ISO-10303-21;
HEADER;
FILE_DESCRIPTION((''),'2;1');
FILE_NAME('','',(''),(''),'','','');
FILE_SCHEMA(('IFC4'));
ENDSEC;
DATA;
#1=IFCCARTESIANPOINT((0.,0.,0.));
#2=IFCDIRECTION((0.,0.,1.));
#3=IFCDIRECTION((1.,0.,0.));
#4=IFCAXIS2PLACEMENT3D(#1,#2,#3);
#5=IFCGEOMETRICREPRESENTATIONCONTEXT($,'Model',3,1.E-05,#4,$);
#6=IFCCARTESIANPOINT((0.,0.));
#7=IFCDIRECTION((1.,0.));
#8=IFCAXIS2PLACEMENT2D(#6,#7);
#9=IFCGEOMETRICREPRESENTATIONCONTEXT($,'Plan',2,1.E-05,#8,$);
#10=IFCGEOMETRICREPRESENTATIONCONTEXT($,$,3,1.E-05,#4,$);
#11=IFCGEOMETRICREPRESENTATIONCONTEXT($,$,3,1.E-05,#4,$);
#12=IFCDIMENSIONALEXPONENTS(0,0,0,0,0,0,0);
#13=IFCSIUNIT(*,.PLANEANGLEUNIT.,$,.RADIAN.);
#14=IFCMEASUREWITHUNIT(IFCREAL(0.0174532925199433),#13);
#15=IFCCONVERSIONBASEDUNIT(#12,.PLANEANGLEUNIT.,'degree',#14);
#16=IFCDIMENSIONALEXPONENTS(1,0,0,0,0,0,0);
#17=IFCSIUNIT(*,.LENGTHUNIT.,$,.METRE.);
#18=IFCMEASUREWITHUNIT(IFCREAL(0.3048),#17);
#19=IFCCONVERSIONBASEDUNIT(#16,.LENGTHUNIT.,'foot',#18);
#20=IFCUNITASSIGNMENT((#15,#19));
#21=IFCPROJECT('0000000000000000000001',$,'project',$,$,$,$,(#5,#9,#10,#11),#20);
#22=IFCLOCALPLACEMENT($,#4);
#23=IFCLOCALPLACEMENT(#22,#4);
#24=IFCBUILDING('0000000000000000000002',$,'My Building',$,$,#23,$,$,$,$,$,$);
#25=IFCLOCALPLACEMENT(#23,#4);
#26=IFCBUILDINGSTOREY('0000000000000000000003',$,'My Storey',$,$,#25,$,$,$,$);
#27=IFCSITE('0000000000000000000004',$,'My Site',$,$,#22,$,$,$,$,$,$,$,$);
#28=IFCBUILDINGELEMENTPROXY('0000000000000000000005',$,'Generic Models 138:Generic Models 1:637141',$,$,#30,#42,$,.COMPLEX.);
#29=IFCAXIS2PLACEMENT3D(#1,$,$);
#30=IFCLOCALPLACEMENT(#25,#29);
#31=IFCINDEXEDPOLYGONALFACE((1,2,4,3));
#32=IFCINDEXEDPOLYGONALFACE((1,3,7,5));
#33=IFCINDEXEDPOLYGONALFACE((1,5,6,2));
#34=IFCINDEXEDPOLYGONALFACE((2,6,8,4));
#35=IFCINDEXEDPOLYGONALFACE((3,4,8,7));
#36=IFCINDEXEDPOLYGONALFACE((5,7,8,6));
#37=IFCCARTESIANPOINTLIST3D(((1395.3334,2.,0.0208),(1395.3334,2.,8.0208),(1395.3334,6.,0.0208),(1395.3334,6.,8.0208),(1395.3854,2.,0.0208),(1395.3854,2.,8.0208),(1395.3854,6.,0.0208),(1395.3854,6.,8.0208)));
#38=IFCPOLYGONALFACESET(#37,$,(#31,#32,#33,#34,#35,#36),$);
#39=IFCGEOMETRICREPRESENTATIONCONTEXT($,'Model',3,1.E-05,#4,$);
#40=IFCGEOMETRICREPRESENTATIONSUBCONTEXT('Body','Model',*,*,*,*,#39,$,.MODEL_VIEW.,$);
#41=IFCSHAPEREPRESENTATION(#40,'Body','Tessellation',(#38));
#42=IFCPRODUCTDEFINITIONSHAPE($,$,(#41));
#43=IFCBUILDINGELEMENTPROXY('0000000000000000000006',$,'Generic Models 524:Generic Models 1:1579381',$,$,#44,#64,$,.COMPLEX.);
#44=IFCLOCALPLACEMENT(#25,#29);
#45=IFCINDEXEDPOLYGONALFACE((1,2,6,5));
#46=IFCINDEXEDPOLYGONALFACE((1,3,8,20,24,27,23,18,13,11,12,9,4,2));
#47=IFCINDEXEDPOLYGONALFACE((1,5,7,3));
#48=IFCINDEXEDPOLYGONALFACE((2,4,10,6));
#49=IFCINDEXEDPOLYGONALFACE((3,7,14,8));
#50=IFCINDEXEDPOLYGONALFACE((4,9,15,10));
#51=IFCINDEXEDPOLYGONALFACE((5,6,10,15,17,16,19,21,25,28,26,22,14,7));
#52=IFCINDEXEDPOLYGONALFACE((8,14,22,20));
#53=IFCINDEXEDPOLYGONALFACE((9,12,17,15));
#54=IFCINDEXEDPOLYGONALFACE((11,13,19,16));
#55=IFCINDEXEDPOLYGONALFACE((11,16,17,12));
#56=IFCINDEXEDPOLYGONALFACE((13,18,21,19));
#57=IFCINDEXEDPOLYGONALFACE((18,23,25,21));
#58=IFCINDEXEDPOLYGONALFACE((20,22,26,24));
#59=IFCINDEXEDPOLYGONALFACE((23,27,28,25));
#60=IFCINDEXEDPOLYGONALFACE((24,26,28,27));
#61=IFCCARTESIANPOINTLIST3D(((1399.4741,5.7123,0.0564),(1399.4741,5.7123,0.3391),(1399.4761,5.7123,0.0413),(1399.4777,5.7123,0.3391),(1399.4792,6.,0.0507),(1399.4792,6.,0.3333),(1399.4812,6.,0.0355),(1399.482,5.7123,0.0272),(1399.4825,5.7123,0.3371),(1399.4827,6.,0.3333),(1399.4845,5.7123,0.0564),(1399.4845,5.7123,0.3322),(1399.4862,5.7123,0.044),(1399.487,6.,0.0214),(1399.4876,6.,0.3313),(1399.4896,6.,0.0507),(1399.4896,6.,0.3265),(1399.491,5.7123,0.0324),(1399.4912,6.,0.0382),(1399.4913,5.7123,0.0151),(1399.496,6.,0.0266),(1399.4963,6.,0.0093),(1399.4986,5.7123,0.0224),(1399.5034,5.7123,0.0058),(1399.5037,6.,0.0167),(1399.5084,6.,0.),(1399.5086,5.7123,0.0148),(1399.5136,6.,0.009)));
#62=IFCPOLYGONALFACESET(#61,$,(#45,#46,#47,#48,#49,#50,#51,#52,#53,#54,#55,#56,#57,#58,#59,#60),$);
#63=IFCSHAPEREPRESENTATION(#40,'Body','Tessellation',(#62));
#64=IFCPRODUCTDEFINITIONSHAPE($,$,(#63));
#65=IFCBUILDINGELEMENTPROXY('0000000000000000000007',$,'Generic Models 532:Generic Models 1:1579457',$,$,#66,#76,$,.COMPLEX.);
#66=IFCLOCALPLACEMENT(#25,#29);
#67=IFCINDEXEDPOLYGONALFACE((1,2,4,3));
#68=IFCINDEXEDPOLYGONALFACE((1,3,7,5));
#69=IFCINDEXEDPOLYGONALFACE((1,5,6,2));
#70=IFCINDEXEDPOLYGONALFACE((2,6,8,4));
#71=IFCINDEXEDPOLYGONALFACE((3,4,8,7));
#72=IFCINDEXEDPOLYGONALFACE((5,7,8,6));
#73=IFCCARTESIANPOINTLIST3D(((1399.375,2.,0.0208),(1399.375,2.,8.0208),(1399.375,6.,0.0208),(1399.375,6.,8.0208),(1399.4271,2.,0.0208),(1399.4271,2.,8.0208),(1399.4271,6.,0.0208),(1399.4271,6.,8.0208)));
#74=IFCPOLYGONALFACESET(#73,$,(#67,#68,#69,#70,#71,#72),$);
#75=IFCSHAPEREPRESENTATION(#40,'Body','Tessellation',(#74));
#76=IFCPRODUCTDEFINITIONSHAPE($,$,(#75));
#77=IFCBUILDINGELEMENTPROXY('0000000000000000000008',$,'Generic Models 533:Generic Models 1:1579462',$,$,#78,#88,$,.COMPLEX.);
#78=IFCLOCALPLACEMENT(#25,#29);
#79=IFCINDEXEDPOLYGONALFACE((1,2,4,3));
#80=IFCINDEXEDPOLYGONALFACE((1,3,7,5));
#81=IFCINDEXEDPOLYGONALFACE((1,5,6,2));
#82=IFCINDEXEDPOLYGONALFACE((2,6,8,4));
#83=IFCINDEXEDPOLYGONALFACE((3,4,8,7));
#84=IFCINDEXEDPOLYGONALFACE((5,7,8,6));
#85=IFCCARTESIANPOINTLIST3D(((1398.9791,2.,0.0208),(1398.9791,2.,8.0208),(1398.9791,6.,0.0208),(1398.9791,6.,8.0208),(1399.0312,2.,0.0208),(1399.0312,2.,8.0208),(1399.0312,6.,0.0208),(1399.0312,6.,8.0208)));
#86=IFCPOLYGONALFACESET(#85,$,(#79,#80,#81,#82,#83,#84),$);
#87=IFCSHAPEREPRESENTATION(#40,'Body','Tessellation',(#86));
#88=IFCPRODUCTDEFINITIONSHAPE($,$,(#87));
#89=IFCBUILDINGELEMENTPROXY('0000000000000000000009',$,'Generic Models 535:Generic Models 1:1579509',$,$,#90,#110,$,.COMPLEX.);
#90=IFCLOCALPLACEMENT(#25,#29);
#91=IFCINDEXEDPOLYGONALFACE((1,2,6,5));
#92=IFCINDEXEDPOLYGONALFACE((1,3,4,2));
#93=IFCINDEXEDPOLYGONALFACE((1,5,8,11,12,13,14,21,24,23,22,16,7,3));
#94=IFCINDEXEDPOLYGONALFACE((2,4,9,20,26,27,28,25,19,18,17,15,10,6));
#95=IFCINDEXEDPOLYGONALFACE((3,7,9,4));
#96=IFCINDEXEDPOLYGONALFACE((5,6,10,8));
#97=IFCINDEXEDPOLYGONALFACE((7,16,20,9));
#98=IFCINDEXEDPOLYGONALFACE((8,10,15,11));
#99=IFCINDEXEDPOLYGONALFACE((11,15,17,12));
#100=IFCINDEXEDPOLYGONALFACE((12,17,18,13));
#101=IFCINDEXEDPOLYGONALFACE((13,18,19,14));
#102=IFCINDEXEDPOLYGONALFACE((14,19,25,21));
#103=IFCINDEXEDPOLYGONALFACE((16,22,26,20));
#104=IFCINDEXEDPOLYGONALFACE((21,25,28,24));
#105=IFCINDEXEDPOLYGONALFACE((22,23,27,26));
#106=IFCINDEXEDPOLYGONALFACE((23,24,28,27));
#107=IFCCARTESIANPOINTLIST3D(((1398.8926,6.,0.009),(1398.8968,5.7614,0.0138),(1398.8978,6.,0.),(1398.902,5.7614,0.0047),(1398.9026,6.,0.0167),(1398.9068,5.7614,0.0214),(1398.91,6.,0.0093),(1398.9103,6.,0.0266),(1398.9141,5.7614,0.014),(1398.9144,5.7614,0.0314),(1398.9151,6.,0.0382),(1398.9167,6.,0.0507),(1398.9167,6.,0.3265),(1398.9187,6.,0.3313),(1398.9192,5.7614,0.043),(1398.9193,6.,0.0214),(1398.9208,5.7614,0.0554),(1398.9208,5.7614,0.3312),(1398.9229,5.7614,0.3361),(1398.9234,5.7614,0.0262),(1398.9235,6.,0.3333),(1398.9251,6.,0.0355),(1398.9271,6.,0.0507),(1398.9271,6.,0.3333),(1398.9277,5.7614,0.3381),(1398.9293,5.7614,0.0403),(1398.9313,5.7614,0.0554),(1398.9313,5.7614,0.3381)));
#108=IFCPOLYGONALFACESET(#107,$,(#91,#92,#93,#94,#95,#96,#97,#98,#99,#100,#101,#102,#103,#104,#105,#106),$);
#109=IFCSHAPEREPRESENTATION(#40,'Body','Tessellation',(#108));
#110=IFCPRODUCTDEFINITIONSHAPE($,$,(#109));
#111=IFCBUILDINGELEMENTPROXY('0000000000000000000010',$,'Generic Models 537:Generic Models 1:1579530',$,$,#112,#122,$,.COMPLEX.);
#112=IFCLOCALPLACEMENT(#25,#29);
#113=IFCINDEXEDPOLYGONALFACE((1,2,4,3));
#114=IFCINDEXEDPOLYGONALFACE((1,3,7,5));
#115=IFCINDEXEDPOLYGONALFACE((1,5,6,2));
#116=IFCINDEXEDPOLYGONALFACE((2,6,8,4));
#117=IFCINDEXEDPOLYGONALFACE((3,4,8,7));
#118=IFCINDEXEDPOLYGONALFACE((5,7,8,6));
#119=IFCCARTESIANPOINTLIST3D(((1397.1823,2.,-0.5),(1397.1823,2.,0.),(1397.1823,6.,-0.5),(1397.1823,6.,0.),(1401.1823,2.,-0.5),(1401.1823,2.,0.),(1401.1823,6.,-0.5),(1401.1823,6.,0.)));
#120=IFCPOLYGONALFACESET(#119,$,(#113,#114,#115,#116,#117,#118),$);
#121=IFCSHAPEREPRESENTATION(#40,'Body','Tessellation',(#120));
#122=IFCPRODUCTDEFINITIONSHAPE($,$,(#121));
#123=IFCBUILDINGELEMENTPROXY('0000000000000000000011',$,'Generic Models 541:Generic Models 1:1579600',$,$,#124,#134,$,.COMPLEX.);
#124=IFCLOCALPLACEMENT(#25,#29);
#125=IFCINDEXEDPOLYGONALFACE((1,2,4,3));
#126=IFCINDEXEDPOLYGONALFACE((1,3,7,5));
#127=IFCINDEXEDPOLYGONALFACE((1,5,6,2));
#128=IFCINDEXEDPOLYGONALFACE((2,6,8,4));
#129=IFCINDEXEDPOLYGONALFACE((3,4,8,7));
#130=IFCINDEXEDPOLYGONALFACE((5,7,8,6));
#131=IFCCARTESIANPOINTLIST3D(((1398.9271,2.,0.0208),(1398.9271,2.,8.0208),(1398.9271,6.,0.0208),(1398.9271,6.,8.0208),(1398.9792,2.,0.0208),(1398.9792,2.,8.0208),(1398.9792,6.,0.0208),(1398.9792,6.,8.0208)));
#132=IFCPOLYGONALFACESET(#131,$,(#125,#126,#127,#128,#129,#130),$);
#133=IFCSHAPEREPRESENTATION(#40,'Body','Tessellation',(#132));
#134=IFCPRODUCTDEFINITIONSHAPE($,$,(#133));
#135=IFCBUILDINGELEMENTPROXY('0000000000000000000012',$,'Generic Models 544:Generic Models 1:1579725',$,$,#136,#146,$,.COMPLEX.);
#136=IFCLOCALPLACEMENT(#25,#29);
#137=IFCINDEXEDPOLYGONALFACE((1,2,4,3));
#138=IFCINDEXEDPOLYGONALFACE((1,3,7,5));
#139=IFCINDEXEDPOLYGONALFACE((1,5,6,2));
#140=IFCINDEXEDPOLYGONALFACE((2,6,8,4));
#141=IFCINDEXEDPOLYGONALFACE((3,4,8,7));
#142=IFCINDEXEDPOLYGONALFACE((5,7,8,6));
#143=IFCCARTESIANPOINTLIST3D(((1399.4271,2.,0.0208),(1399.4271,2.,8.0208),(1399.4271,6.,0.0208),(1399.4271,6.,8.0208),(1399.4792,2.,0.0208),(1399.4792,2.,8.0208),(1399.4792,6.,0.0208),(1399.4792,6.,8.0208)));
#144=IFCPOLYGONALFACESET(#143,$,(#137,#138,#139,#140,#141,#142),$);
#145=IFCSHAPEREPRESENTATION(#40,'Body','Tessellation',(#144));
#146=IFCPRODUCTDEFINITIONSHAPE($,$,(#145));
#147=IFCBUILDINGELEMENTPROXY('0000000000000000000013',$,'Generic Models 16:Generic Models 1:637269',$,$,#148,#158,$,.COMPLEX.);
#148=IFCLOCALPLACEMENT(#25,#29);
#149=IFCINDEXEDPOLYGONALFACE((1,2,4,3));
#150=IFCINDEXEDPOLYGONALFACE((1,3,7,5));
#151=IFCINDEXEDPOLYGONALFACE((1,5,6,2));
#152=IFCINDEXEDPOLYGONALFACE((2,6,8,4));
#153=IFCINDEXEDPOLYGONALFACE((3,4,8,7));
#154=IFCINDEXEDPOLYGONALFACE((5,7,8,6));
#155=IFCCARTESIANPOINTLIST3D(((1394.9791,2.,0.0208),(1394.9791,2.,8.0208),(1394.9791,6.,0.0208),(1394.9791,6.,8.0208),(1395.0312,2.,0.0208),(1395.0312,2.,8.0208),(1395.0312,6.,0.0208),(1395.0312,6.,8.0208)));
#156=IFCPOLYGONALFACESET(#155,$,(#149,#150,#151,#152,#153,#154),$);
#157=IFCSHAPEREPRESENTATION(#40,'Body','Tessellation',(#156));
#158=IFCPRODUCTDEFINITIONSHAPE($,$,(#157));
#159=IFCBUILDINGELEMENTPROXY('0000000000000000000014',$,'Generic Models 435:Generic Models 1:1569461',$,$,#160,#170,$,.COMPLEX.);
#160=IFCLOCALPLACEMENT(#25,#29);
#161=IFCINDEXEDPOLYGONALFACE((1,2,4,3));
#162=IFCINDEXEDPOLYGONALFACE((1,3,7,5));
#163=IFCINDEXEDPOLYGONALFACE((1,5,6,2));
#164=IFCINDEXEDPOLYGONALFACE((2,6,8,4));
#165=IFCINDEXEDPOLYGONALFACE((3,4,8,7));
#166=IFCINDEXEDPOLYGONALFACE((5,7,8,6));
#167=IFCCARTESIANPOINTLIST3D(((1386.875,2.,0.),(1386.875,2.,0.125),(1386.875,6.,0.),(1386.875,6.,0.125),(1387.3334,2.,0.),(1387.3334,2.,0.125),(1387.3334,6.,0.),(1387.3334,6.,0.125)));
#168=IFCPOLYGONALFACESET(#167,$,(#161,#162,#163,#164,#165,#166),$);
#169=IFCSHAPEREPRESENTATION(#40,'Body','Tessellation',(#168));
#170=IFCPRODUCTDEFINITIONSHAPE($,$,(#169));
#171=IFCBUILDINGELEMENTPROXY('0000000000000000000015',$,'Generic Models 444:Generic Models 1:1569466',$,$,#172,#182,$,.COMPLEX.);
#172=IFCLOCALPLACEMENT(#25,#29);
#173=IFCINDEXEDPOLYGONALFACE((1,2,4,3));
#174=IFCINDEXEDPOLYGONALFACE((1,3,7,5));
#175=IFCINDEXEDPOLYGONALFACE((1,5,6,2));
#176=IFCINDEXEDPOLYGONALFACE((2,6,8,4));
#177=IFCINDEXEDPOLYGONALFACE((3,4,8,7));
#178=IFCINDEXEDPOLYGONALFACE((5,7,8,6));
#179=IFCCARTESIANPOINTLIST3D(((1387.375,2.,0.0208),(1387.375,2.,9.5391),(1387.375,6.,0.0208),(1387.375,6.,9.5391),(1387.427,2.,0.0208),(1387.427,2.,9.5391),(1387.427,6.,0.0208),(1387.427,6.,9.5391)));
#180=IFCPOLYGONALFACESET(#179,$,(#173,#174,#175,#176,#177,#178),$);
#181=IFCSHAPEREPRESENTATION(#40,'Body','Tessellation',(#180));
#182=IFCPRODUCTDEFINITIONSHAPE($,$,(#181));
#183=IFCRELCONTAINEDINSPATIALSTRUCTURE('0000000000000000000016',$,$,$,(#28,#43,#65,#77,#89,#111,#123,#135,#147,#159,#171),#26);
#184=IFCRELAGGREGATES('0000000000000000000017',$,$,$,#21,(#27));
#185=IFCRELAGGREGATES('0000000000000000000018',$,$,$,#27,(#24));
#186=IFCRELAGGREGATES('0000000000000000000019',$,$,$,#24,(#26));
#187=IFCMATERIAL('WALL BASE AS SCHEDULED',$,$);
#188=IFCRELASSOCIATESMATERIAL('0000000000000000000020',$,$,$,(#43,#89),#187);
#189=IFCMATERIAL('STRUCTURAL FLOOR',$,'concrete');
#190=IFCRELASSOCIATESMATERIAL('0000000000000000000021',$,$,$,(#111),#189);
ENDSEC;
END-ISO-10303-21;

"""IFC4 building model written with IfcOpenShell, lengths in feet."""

from ifc_helpers import new_model, entity, si_unit, converted_unit, frame, origin_with_axes, origin_2d_with_axis, place, context, subcontext, project, spatial, polyline, line, indexed_curve, outline, extrude, material, element, save


model = new_model("IFC4")

# Units and contexts
model_context_1 = context("Model", 3, precision=1e-05, world=origin_with_axes())
plan_context = context("Plan", 2, precision=1e-05, world=origin_2d_with_axis())
model_context_2 = context("Model", 3, precision=1e-05, world=origin_with_axes())
context_of_model_1 = context(None, 3, precision=1e-05, world=origin_with_axes())
context_of_model_2 = context(None, 3, precision=1e-05, world=origin_with_axes())
body_context_1 = subcontext(model_context_2, "Body", "Model", "MODEL_VIEW")
ifc_project = project(units=[converted_unit("PLANEANGLEUNIT", "degree", entity("IfcReal", 0.0174532925199433), si_unit("PLANEANGLEUNIT", "RADIAN"), dimensions=[0, 0, 0, 0, 0, 0, 0]), converted_unit("LENGTHUNIT", "foot", entity("IfcReal", 0.3048), si_unit("LENGTHUNIT", "METRE"), dimensions=[1, 0, 0, 0, 0, 0, 0])], contexts=[model_context_1, plan_context, context_of_model_1, context_of_model_2])

# Site, building, storey
site_placement = place(None, origin_with_axes())
site = spatial("IfcSite", under=ifc_project, at=site_placement, Name="My Site")
building_placement = place(site_placement, origin_with_axes())
building = spatial("IfcBuilding", under=site, at=building_placement, Name="My Building")
storey_placement = place(building_placement, origin_with_axes())
storey = spatial("IfcBuildingStorey", under=building, at=storey_placement, Name="My Storey")

# Building element proxies
proxy_1_placement = place(storey_placement, frame((1395.3334, 6.0, 0.0208), z_axis=(0.0, -1.0, 0.0), x_axis=(0.0, 0.0, 1.0)))
element("IfcBuildingElementProxy", 1, at=proxy_1_placement, inside=storey, Name="Generic Models 138:Generic Models 1:637141", PredefinedType="COMPLEX", context=body_context_1, shape_type="SweptSolid", body=[
    extrude(outline(indexed_curve([(-0.026, -4.0), (0.026, -4.0), (0.026, 4.0), (-0.026, 4.0)], segments=[line(4, 1), line(1, 2), line(2, 3), line(3, 4)], self_intersect=False)), frame((4.0, -0.026, 0.0), z_axis=(0.0, 0.0, -1.0), x_axis=(0.0, 1.0, 0.0)), (0.0, 0.0, -1.0), 4.0),
])
ifc_material_1 = material(Name="WALL BASE AS SCHEDULED")
proxy_2_placement = place(storey_placement, frame((1399.4792, 6.0, 0.0), z_axis=(0.0, -1.0, 0.0), x_axis=(0.0, 0.0, 1.0)))
element("IfcBuildingElementProxy", 2, at=proxy_2_placement, inside=storey, material=ifc_material_1, Name="Generic Models 524:Generic Models 1:1579381", PredefinedType="COMPLEX", context=body_context_1, shape_type="SweptSolid", body=[
    extrude(outline(polyline([(0.0865, 0.0), (0.0968, -0.0072), (0.105, -0.0167), (0.1137, -0.0111), (0.1038, 0.0006), (0.0913, 0.0093), (0.0769, 0.0144), (0.0617, 0.0157), (-0.2206, 0.0019), (-0.2205, -0.0017), (-0.2182, -0.0064), (-0.2133, -0.0082), (0.0622, 0.0053), (0.0747, 0.0042), (0.0865, 0.0)])), frame((0.113, -0.0126, 0.0), z_axis=(0.0, 0.0, -1.0), x_axis=(-0.998808, -0.048806, 0.0)), (-0.020832, 0.016543, -0.999646), 0.2878),
])
proxy_3_placement = place(storey_placement, frame((1399.375, 6.0, 0.0208), z_axis=(0.0, -1.0, 0.0), x_axis=(0.0, 0.0, 1.0)))
element("IfcBuildingElementProxy", 3, at=proxy_3_placement, inside=storey, Name="Generic Models 532:Generic Models 1:1579457", PredefinedType="COMPLEX", context=body_context_1, shape_type="SweptSolid", body=[
    extrude(outline(polyline([(-4.0, -0.026), (4.0, -0.026), (4.0, 0.026), (-4.0, 0.026), (-4.0, -0.026)])), frame((4.0, -0.026, 0.0), z_axis=(0.0, 0.0, -1.0), x_axis=(1.0, 0.0, 0.0)), (0.0, 0.0, -1.0), 4.0),
])
proxy_4_placement = place(storey_placement, frame((1398.9791, 6.0, 0.0208), z_axis=(0.0, -1.0, 0.0), x_axis=(0.0, 0.0, 1.0)))
element("IfcBuildingElementProxy", 4, at=proxy_4_placement, inside=storey, Name="Generic Models 533:Generic Models 1:1579462", PredefinedType="COMPLEX", context=body_context_1, shape_type="SweptSolid", body=[
    extrude(outline(polyline([(-0.026, -4.0), (0.026, -4.0), (0.026, 4.0), (-0.026, 4.0), (-0.026, -4.0)])), frame((4.0, -0.026, 0.0), z_axis=(0.0, 0.0, -1.0), x_axis=(0.0, -1.0, 0.0)), (0.0, 0.0, -1.0), 4.0),
])
proxy_5_placement = place(storey_placement, frame((1398.8926, 6.0, 0.0), z_axis=(0.0, -1.0, 0.0), x_axis=(0.0, 0.0, 1.0)))
element("IfcBuildingElementProxy", 5, at=proxy_5_placement, inside=storey, material=ifc_material_1, Name="Generic Models 535:Generic Models 1:1579509", PredefinedType="COMPLEX", context=body_context_1, shape_type="SweptSolid", body=[
    extrude(outline(polyline([(-0.2203, -0.0126), (0.0624, -0.0126), (0.0775, -0.0106), (0.0916, -0.0048), (0.1037, 0.0045), (0.113, 0.0166), (0.104, 0.0218), (0.0964, 0.0119), (0.0864, 0.0042), (0.0748, -0.0006), (0.0624, -0.0022), (-0.2134, -0.0022), (-0.2183, -0.0042), (-0.2203, -0.0091), (-0.2203, -0.0126)])), frame((0.113, -0.0218, 0.0), z_axis=(0.0, 0.0, -1.0), x_axis=(-1.0, 0.0, 0.0)), (-0.01982, -0.017382, -0.999652), 0.2387),
])
ifc_material_2 = material(Name="STRUCTURAL FLOOR", Category="concrete")
proxy_6_placement = place(storey_placement, frame((1397.1823, 6.0, -0.5), z_axis=(0.0, -1.0, 0.0), x_axis=(0.0, 0.0, 1.0)))
element("IfcBuildingElementProxy", 6, at=proxy_6_placement, inside=storey, material=ifc_material_2, Name="Generic Models 537:Generic Models 1:1579530", PredefinedType="COMPLEX", context=body_context_1, shape_type="SweptSolid", body=[
    extrude(outline(polyline([(-0.25, -2.0), (0.25, -2.0), (0.25, 2.0), (-0.25, 2.0), (-0.25, -2.0)])), frame((0.25, -2.0, 0.0), z_axis=(0.0, 0.0, -1.0), x_axis=(1.0, 0.0, 0.0)), (0.0, 0.0, -1.0), 4.0),
])
proxy_7_placement = place(storey_placement, frame((1398.9271, 6.0, 0.0208), z_axis=(0.0, -1.0, 0.0), x_axis=(0.0, 0.0, 1.0)))
element("IfcBuildingElementProxy", 7, at=proxy_7_placement, inside=storey, Name="Generic Models 541:Generic Models 1:1579600", PredefinedType="COMPLEX", context=body_context_1, shape_type="SweptSolid", body=[
    extrude(outline(polyline([(-4.0, -0.026), (4.0, -0.026), (4.0, 0.026), (-4.0, 0.026), (-4.0, -0.026)])), frame((4.0, -0.026, 0.0), z_axis=(0.0, 0.0, -1.0), x_axis=(1.0, 0.0, 0.0)), (0.0, 0.0, -1.0), 4.0),
])
proxy_8_placement = place(storey_placement, frame((1399.4271, 6.0, 0.0208), z_axis=(0.0, -1.0, 0.0), x_axis=(0.0, 0.0, 1.0)))
element("IfcBuildingElementProxy", 8, at=proxy_8_placement, inside=storey, Name="Generic Models 544:Generic Models 1:1579725", PredefinedType="COMPLEX", context=body_context_1, shape_type="SweptSolid", body=[
    extrude(outline(indexed_curve([(-4.0, -0.026), (4.0, -0.026), (4.0, 0.026), (-4.0, 0.026)], segments=[line(3, 2), line(2, 1), line(1, 4), line(4, 3)], self_intersect=False)), frame((4.0, -0.026, 0.0), z_axis=(0.0, 0.0, -1.0), x_axis=(1.0, 0.0, 0.0)), (0.0, 0.0, -1.0), 4.0),
])
proxy_9_placement = place(storey_placement, frame((1394.9791, 6.0, 0.0208), z_axis=(0.0, -1.0, 0.0), x_axis=(0.0, 0.0, 1.0)))
element("IfcBuildingElementProxy", 9, at=proxy_9_placement, inside=storey, Name="Generic Models 16:Generic Models 1:637269", PredefinedType="COMPLEX", context=body_context_1, shape_type="SweptSolid", body=[
    extrude(outline(polyline([(-0.026, -4.0), (0.026, -4.0), (0.026, 4.0), (-0.026, 4.0), (-0.026, -4.0)])), frame((4.0, -0.026, 0.0), z_axis=(0.0, 0.0, -1.0), x_axis=(0.0, 1.0, 0.0)), (0.0, 0.0, -1.0), 4.0),
])
proxy_10_placement = place(storey_placement, frame((1386.875, 6.0, 0.0), z_axis=(0.0, -1.0, 0.0), x_axis=(0.0, 0.0, 1.0)))
element("IfcBuildingElementProxy", 10, at=proxy_10_placement, inside=storey, Name="Generic Models 435:Generic Models 1:1569461", PredefinedType="COMPLEX", context=body_context_1, shape_type="SweptSolid", body=[
    extrude(outline(polyline([(-0.2292, -0.0625), (0.2292, -0.0625), (0.2292, 0.0625), (-0.2292, 0.0625), (-0.2292, -0.0625)])), frame((0.0625, -0.2292, 0.0), z_axis=(0.0, 0.0, -1.0), x_axis=(0.0, 1.0, 0.0)), (0.0, 0.0, -1.0), 4.0),
])
proxy_11_placement = place(storey_placement, frame((1387.375, 6.0, 0.0208), z_axis=(0.0, -1.0, 0.0), x_axis=(0.0, 0.0, 1.0)))
element("IfcBuildingElementProxy", 11, at=proxy_11_placement, inside=storey, Name="Generic Models 444:Generic Models 1:1569466", PredefinedType="COMPLEX", context=body_context_1, shape_type="SweptSolid", body=[
    extrude(outline(polyline([(-4.7591, -0.026), (4.7591, -0.026), (4.7591, 0.026), (-4.7591, 0.026), (-4.7591, -0.026)])), frame((4.7591, -0.026, 0.0), z_axis=(0.0, 0.0, -1.0), x_axis=(1.0, 0.0, 0.0)), (0.0, 0.0, -1.0), 4.0),
])

save(model, "model.ifc")
